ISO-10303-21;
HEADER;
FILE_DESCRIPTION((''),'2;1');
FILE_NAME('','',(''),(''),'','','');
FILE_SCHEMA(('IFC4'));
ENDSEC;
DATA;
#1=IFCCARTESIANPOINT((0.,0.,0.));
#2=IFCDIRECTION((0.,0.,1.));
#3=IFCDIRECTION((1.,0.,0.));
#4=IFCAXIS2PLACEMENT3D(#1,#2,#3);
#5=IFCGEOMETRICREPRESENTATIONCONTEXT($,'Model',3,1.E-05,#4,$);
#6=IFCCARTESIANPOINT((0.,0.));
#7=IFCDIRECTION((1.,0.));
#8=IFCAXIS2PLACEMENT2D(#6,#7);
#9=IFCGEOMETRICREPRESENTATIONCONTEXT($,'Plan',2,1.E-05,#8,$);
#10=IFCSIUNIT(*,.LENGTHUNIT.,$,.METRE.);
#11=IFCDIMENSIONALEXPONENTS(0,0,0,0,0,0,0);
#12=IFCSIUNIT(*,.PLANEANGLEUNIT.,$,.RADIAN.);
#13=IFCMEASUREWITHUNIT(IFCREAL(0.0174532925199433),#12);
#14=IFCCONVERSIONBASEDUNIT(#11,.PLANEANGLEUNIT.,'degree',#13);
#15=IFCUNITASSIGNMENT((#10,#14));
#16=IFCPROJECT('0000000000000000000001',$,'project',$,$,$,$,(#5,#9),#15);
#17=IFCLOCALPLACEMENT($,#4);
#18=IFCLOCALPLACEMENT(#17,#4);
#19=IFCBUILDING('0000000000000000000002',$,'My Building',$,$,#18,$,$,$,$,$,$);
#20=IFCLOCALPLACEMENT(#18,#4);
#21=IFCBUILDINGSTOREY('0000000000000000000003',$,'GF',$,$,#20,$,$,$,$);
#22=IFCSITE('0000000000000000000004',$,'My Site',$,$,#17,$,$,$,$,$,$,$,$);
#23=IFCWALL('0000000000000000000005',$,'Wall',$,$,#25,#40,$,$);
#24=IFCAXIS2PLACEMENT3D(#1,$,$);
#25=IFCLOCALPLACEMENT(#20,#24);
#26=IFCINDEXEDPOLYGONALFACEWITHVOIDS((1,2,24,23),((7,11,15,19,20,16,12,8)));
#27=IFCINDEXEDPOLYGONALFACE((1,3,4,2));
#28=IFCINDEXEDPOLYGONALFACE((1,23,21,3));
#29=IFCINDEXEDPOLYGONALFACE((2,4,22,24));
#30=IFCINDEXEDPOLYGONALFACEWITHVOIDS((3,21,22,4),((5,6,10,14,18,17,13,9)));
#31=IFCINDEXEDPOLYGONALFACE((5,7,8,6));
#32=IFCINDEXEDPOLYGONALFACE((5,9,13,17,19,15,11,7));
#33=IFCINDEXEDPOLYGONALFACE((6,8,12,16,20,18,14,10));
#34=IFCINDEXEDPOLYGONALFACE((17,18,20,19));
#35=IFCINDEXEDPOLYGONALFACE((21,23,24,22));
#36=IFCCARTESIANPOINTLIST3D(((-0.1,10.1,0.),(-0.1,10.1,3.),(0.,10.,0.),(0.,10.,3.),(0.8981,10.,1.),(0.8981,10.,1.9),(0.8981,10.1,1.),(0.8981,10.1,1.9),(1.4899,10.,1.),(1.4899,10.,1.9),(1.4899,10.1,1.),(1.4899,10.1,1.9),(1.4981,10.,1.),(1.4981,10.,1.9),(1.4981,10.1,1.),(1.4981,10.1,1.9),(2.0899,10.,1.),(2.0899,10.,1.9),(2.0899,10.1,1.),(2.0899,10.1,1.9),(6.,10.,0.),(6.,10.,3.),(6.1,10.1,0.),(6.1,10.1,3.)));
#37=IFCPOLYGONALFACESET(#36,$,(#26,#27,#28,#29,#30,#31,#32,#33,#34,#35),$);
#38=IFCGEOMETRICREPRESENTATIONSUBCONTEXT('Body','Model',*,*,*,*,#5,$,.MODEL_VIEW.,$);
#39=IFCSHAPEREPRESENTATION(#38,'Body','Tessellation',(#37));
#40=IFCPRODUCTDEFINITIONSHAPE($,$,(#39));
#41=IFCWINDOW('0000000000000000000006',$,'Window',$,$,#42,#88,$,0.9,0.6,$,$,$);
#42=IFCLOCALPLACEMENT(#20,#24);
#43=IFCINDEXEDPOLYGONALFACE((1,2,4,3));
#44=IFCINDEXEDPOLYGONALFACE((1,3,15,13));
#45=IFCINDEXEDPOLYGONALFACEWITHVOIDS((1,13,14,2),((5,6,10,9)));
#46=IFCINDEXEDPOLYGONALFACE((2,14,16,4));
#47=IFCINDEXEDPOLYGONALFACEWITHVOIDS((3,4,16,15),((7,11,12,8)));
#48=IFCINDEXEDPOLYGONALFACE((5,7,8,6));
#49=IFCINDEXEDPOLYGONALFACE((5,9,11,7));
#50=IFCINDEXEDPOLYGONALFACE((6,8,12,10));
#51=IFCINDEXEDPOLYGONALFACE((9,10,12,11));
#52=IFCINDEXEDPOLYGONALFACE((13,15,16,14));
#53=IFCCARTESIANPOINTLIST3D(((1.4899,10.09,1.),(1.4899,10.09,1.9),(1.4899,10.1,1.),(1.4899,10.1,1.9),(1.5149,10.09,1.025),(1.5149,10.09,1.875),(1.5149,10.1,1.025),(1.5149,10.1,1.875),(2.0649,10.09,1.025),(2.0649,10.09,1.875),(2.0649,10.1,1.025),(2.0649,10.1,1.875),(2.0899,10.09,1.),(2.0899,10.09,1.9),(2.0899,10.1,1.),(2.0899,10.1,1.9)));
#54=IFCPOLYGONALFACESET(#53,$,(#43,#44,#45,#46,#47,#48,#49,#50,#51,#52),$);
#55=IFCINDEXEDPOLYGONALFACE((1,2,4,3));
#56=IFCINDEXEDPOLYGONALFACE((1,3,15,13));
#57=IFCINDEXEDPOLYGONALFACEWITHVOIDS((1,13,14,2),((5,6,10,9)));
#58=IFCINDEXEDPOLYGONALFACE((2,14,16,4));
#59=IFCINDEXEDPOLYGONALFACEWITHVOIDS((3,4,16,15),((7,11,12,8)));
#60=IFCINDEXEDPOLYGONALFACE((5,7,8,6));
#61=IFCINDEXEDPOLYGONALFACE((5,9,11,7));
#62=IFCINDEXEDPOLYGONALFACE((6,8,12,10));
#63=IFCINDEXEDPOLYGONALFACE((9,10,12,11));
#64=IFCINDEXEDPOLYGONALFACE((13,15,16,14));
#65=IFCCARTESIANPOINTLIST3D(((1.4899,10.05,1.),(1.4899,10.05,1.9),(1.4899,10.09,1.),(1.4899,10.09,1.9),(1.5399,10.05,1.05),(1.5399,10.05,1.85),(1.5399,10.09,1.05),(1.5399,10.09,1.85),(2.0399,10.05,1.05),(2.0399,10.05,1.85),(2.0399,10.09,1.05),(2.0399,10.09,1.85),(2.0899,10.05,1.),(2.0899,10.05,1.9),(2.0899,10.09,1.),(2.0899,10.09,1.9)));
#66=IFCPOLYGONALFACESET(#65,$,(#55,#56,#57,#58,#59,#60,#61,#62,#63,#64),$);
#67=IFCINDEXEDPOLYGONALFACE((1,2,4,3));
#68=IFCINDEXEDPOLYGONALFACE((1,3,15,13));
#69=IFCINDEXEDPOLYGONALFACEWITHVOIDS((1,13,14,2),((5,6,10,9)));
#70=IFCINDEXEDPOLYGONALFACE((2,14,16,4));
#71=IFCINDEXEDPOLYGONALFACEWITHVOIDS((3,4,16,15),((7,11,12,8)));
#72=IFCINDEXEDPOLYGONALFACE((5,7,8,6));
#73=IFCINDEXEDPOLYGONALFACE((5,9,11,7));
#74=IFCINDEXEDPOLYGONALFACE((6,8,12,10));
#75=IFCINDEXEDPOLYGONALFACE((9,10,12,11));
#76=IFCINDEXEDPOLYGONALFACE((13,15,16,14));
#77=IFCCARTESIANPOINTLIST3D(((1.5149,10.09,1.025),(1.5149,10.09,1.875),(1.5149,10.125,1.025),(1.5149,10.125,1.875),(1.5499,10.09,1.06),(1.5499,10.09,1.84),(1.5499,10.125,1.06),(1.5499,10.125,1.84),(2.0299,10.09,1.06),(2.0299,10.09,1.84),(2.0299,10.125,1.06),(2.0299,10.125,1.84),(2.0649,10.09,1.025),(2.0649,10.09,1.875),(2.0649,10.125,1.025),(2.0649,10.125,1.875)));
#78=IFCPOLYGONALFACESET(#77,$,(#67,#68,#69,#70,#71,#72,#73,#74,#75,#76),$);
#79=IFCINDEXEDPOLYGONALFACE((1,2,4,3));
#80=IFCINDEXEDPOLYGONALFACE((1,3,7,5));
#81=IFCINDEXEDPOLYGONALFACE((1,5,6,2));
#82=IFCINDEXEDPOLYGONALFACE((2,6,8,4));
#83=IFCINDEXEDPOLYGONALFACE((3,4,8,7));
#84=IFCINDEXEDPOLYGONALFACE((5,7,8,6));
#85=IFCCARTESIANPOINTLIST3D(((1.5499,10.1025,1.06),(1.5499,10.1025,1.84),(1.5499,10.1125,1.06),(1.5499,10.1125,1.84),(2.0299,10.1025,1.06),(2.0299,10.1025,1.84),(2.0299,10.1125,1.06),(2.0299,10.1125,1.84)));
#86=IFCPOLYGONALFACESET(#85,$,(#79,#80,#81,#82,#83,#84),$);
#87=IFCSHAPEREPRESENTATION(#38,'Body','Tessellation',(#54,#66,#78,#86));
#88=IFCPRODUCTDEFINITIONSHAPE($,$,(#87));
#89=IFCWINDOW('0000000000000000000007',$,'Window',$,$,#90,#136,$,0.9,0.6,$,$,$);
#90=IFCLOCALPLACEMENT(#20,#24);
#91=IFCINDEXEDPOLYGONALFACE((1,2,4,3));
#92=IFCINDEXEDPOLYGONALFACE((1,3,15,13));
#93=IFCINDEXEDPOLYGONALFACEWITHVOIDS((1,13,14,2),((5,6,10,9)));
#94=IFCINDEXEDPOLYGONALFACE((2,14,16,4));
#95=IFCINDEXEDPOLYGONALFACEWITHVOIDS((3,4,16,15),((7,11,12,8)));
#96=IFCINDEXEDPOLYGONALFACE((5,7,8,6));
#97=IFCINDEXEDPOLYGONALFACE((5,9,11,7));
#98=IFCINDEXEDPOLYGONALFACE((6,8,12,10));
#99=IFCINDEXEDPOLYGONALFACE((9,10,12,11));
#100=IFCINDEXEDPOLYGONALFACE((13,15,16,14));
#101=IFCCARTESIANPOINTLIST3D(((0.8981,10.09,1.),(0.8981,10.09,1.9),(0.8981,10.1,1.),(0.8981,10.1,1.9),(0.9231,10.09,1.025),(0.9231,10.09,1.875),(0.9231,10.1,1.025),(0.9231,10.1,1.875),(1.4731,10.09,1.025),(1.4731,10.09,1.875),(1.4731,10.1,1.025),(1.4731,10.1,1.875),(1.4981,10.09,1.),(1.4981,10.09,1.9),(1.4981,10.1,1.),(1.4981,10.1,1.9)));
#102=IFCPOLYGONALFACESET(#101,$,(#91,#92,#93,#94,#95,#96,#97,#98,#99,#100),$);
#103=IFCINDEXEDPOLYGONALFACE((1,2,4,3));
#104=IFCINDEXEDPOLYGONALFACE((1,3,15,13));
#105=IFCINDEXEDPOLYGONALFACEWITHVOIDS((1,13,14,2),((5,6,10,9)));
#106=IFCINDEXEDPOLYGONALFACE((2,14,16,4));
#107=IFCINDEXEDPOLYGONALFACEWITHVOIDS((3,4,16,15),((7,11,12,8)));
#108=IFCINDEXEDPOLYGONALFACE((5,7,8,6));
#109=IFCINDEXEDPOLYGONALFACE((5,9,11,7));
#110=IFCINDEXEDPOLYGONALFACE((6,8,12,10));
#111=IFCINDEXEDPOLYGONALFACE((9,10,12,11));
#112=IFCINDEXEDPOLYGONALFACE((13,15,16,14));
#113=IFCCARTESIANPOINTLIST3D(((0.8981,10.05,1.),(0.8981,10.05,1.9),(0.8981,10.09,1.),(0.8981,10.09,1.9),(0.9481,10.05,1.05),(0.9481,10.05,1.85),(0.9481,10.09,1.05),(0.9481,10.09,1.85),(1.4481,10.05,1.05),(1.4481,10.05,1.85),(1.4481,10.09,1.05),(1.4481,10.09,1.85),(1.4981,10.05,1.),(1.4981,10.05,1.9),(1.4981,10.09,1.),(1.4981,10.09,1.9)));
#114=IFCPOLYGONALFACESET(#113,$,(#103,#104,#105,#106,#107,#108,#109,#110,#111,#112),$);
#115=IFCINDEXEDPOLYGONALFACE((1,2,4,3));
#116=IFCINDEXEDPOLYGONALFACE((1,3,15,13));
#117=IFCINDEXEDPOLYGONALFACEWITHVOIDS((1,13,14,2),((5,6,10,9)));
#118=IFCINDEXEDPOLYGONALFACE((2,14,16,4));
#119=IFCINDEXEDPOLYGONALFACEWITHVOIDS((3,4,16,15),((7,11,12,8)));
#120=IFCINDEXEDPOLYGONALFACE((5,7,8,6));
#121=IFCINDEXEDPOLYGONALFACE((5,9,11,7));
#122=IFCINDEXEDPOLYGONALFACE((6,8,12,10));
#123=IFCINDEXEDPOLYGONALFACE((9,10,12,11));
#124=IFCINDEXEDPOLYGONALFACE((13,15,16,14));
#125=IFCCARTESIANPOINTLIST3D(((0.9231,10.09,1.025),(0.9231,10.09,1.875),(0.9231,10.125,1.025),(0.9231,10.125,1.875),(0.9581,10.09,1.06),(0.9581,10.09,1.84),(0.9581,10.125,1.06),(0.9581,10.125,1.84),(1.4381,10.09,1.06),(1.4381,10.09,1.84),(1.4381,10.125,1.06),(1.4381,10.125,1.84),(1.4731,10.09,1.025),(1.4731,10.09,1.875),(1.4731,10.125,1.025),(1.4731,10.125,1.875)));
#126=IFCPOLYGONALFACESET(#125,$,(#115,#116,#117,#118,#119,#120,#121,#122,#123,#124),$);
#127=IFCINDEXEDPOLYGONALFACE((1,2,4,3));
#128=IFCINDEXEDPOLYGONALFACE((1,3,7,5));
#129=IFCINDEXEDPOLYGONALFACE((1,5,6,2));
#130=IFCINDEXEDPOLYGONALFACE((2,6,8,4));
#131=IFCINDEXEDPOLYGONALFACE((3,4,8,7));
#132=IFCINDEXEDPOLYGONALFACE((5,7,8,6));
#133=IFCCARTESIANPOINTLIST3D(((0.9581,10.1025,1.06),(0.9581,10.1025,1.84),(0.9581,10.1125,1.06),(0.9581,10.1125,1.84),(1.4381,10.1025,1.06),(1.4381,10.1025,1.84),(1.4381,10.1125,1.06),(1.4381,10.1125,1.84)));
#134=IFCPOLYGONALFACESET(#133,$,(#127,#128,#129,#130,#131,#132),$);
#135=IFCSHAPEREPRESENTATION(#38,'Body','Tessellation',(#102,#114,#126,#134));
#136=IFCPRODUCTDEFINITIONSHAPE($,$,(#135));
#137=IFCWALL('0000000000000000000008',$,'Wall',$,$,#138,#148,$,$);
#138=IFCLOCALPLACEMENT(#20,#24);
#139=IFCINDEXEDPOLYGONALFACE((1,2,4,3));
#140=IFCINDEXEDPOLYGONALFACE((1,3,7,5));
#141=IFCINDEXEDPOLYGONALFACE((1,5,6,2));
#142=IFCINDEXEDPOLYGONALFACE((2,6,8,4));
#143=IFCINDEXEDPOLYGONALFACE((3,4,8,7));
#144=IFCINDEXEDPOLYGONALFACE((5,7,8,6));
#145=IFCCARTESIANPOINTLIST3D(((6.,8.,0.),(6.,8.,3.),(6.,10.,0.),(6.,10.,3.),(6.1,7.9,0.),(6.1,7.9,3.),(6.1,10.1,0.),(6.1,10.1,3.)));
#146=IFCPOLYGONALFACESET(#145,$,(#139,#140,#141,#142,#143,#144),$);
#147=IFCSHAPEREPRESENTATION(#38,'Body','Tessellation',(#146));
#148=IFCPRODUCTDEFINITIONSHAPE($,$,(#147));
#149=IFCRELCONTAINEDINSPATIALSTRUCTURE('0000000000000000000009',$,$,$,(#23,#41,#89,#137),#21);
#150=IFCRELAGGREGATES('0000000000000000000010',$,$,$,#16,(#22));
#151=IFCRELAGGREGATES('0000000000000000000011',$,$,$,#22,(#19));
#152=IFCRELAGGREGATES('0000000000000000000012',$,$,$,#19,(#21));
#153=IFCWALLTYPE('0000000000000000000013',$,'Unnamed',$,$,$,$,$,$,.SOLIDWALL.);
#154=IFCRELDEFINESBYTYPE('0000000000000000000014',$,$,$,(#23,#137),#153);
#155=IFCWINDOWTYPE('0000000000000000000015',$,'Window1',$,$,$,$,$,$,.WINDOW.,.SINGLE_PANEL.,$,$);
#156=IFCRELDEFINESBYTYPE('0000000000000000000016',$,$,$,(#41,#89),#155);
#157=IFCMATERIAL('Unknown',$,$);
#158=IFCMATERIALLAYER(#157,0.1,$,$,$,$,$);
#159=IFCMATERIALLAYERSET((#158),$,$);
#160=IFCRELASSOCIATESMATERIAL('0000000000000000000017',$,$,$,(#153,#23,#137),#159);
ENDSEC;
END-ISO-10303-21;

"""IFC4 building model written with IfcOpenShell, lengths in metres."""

from ifc_helpers import new_model, entity, si_unit, converted_unit, frame, origin_with_axes, origin_2d_with_axis, place, context, subcontext, project, spatial, line, indexed_curve, outline, extrude, shape, source, transform, mapped, material, layer, layer_set, layer_usage, type_object, type_shapes, element, fill, save


model = new_model("IFC4")

# Units and contexts
model_context = context("Model", 3, precision=1e-05, world=origin_with_axes())
plan_context = context("Plan", 2, precision=1e-05, world=origin_2d_with_axis())
body_context_1 = subcontext(model_context, "Body", "Model", "MODEL_VIEW")
body_context_2 = subcontext(plan_context, "Body", "Plan", "PLAN_VIEW")
ifc_project = project(units=[si_unit("LENGTHUNIT", "METRE"), converted_unit("PLANEANGLEUNIT", "degree", entity("IfcReal", 0.0174532925199433), si_unit("PLANEANGLEUNIT", "RADIAN"), dimensions=[0, 0, 0, 0, 0, 0, 0])], contexts=[model_context, plan_context])

# Site, building, storey
site_placement = place(None, origin_with_axes())
site = spatial("IfcSite", under=ifc_project, at=site_placement, Name="My Site")
building_placement = place(site_placement, origin_with_axes())
building = spatial("IfcBuilding", under=site, at=building_placement, Name="My Building")
storey_placement = place(building_placement, origin_with_axes())
storey = spatial("IfcBuildingStorey", under=building, at=storey_placement, Name="GF")

# Shared definitions
ifc_material = material(Name="Unknown")

# Shared definitions
ifc_layer_1 = layer(ifc_material, 0.1)
ifc_layer_set_1 = layer_set([ifc_layer_1])
wall_type_1 = type_object("IfcWallType", Name="Unnamed", PredefinedType="SOLIDWALL", material=ifc_layer_set_1)

# Wall, openings, windows
ifc_layer_usage_1 = layer_usage(ifc_layer_set_1, "AXIS2", "POSITIVE", 0.0)
wall_1_placement = place(storey_placement, frame((0.0, 10.0, 0.0), z_axis=(0.0, 0.0, 1.0), x_axis=(1.0, 0.0, 0.0)))
wall_1 = element("IfcWall", 1, at=wall_1_placement, inside=storey, type_object=wall_type_1, material=ifc_layer_usage_1, Name="Wall", context=body_context_1, shape_type="SweptSolid", body=[
    extrude(outline(indexed_curve([(0.0, 0.0), (-0.1, 0.1), (6.1, 0.1), (6.0, 0.0)], segments=[line(1, 2, 3, 4, 1)])), origin_with_axes(), (0.0, 0.0, 1.0), 3.0),
])
shared_shape_1 = source(origin_with_axes(), body_context_1, "Body", "SweptSolid", [
    extrude(outline(indexed_curve([(0.0, 0.0), (0.6, 0.0), (0.6, 0.9), (0.0, 0.9)], segments=[line(1, 2, 3, 4, 1)])), frame((0.0, -0.6, 0.0), z_axis=(0.0, -1.0, 0.0), x_axis=(1.0, 0.0, 0.0)), (0.0, 0.0, -1.0), 1.2),
])
opening_1_placement = place(wall_1_placement, frame((1.4899, 0.0, 1.0), z_axis=(0.0, 0.0, 1.0), x_axis=(1.0, 0.0, 0.0)))
opening_1 = element("IfcOpeningElement", 2, at=opening_1_placement, cuts=wall_1, PredefinedType="OPENING", context=body_context_1, shape_type="MappedRepresentation", body=[
    mapped(shared_shape_1, transform((0.0, 0.0, 0.0), x_axis=(1.0, 0.0, 0.0), y_axis=(0.0, 1.0, 0.0), z_axis=(0.0, 0.0, 1.0), scale=1.0)),
])
opening_2_placement = place(wall_1_placement, frame((0.8981, 0.0, 1.0), z_axis=(0.0, 0.0, 1.0), x_axis=(1.0, 0.0, 0.0)))
opening_2 = element("IfcOpeningElement", 3, at=opening_2_placement, cuts=wall_1, PredefinedType="OPENING", context=body_context_1, shape_type="MappedRepresentation", body=[
    mapped(shared_shape_1, transform((0.0, 0.0, 0.0), x_axis=(1.0, 0.0, 0.0), y_axis=(0.0, 1.0, 0.0), z_axis=(0.0, 0.0, 1.0), scale=1.0)),
])
window_type = type_object("IfcWindowType", Name="Window1", PartitioningType="SINGLE_PANEL", PredefinedType="WINDOW")
shared_shape_2 = source(origin_with_axes(), body_context_1, "Body", "SweptSolid", [
    extrude(outline(indexed_curve([(0.0, 0.0), (0.6, 0.0), (0.6, 0.9), (0.0, 0.9)], segments=[line(1, 2, 3, 4, 1)]), holes=[indexed_curve([(0.025, 0.025), (0.575, 0.025), (0.575, 0.875), (0.025, 0.875)], segments=[line(1, 2, 3, 4, 1)])]), frame((0.0, 0.09, 0.0), z_axis=(0.0, -1.0, 0.0), x_axis=(1.0, 0.0, 0.0)), (0.0, 0.0, -1.0), 0.01),
    extrude(outline(indexed_curve([(0.0, 0.0), (0.6, 0.0), (0.6, 0.9), (0.0, 0.9)], segments=[line(1, 2, 3, 4, 1)]), holes=[indexed_curve([(0.05, 0.05), (0.55, 0.05), (0.55, 0.85), (0.05, 0.85)], segments=[line(1, 2, 3, 4, 1)])]), frame((0.0, 0.05, 0.0), z_axis=(0.0, -1.0, 0.0), x_axis=(1.0, 0.0, 0.0)), (0.0, 0.0, -1.0), 0.04),
    extrude(outline(indexed_curve([(0.0, 0.0), (0.55, 0.0), (0.55, 0.85), (0.0, 0.85)], segments=[line(1, 2, 3, 4, 1)]), holes=[indexed_curve([(0.035, 0.035), (0.515, 0.035), (0.515, 0.815), (0.035, 0.815)], segments=[line(1, 2, 3, 4, 1)])]), frame((0.025, 0.09, 0.025), z_axis=(0.0, -1.0, 0.0), x_axis=(1.0, 0.0, 0.0)), (0.0, 0.0, -1.0), 0.035),
    extrude(outline(indexed_curve([(0.035, 0.035), (0.515, 0.035), (0.515, 0.815), (0.035, 0.815)], segments=[line(1, 2, 3, 4, 1)])), frame((0.025, 0.1025, 0.025), z_axis=(0.0, -1.0, 0.0), x_axis=(1.0, 0.0, 0.0)), (0.0, 0.0, -1.0), 0.01),
])
shared_shape_3 = source(origin_with_axes(), body_context_2, "Body", "Curve2D", [
    entity("IfcIndexedPolyCurve", entity("IfcCartesianPointList2D", [[0.05, 0.05], [0.55, 0.05]])),
    entity("IfcIndexedPolyCurve", entity("IfcCartesianPointList2D", [[0.0, 0.1], [0.025, 0.1], [0.025, 0.09], [0.05, 0.09], [0.05, 0.05], [0.0, 0.05]]), [entity("IfcLineIndex", [1, 2, 3, 4, 5, 6, 1])]),
    entity("IfcIndexedPolyCurve", entity("IfcCartesianPointList2D", [[0.6, 0.1], [0.575, 0.1], [0.575, 0.09], [0.55, 0.09], [0.55, 0.05], [0.6, 0.05]]), [entity("IfcLineIndex", [1, 2, 3, 4, 5, 6, 1])]),
    entity("IfcIndexedPolyCurve", entity("IfcCartesianPointList2D", [[0.025, 0.09], [0.06, 0.09], [0.06, 0.125], [0.025, 0.125]]), [entity("IfcLineIndex", [1, 2, 3, 4, 1])]),
    entity("IfcIndexedPolyCurve", entity("IfcCartesianPointList2D", [[0.575, 0.09], [0.54, 0.09], [0.54, 0.125], [0.575, 0.125]]), [entity("IfcLineIndex", [1, 2, 3, 4, 1])]),
    entity("IfcIndexedPolyCurve", entity("IfcCartesianPointList2D", [[0.06, 0.09], [0.54, 0.09]])),
    entity("IfcIndexedPolyCurve", entity("IfcCartesianPointList2D", [[0.06, 0.125], [0.54, 0.125]])),
    entity("IfcIndexedPolyCurve", entity("IfcCartesianPointList2D", [[0.06, 0.1075], [0.54, 0.1075]])),
])
type_shapes(window_type, [shared_shape_2, shared_shape_3])
window_1_placement = place(opening_1_placement, origin_with_axes())
window_1 = element("IfcWindow", 4, at=window_1_placement, inside=storey, type_object=window_type, Name="Window", OverallHeight=0.9, OverallWidth=0.6, shapes=[
    shape(body_context_1, "Body", "MappedRepresentation", [mapped(shared_shape_2, transform((0.0, 0.0, 0.0), x_axis=(1.0, 0.0, 0.0), y_axis=(0.0, 1.0, 0.0), z_axis=(0.0, 0.0, 1.0), scale=1.0))]),
    shape(body_context_2, "Body", "MappedRepresentation", [mapped(shared_shape_3, transform((0.0, 0.0, 0.0), x_axis=(1.0, 0.0, 0.0), y_axis=(0.0, 1.0, 0.0), z_axis=(0.0, 0.0, 1.0), scale=1.0))]),
])
fill(opening_1, window_1)
window_2_placement = place(opening_2_placement, origin_with_axes())
window_2 = element("IfcWindow", 5, at=window_2_placement, inside=storey, type_object=window_type, Name="Window", OverallHeight=0.9, OverallWidth=0.6, shapes=[
    shape(body_context_1, "Body", "MappedRepresentation", [mapped(shared_shape_2, transform((0.0, 0.0, 0.0), x_axis=(1.0, 0.0, 0.0), y_axis=(0.0, 1.0, 0.0), z_axis=(0.0, 0.0, 1.0), scale=1.0))]),
    shape(body_context_2, "Body", "MappedRepresentation", [mapped(shared_shape_3, transform((0.0, 0.0, 0.0), x_axis=(1.0, 0.0, 0.0), y_axis=(0.0, 1.0, 0.0), z_axis=(0.0, 0.0, 1.0), scale=1.0))]),
])
fill(opening_2, window_2)

# Wall
ifc_layer_usage_2 = layer_usage(ifc_layer_set_1, "AXIS2", "POSITIVE", 0.0)
wall_2_placement = place(storey_placement, frame((6.0, 10.0, 0.0), z_axis=(0.0, 0.0, 1.0), x_axis=(0.0, -1.0, 0.0)))
element("IfcWall", 6, at=wall_2_placement, inside=storey, type_object=wall_type_1, material=ifc_layer_usage_2, Name="Wall", context=body_context_1, shape_type="SweptSolid", body=[
    extrude(outline(indexed_curve([(0.0, 0.0), (-0.1, 0.1), (2.1, 0.1), (2.0, 0.0)], segments=[line(1, 2, 3, 4, 1)])), origin_with_axes(), (0.0, 0.0, 1.0), 3.0),
])

save(model, "model.ifc")
